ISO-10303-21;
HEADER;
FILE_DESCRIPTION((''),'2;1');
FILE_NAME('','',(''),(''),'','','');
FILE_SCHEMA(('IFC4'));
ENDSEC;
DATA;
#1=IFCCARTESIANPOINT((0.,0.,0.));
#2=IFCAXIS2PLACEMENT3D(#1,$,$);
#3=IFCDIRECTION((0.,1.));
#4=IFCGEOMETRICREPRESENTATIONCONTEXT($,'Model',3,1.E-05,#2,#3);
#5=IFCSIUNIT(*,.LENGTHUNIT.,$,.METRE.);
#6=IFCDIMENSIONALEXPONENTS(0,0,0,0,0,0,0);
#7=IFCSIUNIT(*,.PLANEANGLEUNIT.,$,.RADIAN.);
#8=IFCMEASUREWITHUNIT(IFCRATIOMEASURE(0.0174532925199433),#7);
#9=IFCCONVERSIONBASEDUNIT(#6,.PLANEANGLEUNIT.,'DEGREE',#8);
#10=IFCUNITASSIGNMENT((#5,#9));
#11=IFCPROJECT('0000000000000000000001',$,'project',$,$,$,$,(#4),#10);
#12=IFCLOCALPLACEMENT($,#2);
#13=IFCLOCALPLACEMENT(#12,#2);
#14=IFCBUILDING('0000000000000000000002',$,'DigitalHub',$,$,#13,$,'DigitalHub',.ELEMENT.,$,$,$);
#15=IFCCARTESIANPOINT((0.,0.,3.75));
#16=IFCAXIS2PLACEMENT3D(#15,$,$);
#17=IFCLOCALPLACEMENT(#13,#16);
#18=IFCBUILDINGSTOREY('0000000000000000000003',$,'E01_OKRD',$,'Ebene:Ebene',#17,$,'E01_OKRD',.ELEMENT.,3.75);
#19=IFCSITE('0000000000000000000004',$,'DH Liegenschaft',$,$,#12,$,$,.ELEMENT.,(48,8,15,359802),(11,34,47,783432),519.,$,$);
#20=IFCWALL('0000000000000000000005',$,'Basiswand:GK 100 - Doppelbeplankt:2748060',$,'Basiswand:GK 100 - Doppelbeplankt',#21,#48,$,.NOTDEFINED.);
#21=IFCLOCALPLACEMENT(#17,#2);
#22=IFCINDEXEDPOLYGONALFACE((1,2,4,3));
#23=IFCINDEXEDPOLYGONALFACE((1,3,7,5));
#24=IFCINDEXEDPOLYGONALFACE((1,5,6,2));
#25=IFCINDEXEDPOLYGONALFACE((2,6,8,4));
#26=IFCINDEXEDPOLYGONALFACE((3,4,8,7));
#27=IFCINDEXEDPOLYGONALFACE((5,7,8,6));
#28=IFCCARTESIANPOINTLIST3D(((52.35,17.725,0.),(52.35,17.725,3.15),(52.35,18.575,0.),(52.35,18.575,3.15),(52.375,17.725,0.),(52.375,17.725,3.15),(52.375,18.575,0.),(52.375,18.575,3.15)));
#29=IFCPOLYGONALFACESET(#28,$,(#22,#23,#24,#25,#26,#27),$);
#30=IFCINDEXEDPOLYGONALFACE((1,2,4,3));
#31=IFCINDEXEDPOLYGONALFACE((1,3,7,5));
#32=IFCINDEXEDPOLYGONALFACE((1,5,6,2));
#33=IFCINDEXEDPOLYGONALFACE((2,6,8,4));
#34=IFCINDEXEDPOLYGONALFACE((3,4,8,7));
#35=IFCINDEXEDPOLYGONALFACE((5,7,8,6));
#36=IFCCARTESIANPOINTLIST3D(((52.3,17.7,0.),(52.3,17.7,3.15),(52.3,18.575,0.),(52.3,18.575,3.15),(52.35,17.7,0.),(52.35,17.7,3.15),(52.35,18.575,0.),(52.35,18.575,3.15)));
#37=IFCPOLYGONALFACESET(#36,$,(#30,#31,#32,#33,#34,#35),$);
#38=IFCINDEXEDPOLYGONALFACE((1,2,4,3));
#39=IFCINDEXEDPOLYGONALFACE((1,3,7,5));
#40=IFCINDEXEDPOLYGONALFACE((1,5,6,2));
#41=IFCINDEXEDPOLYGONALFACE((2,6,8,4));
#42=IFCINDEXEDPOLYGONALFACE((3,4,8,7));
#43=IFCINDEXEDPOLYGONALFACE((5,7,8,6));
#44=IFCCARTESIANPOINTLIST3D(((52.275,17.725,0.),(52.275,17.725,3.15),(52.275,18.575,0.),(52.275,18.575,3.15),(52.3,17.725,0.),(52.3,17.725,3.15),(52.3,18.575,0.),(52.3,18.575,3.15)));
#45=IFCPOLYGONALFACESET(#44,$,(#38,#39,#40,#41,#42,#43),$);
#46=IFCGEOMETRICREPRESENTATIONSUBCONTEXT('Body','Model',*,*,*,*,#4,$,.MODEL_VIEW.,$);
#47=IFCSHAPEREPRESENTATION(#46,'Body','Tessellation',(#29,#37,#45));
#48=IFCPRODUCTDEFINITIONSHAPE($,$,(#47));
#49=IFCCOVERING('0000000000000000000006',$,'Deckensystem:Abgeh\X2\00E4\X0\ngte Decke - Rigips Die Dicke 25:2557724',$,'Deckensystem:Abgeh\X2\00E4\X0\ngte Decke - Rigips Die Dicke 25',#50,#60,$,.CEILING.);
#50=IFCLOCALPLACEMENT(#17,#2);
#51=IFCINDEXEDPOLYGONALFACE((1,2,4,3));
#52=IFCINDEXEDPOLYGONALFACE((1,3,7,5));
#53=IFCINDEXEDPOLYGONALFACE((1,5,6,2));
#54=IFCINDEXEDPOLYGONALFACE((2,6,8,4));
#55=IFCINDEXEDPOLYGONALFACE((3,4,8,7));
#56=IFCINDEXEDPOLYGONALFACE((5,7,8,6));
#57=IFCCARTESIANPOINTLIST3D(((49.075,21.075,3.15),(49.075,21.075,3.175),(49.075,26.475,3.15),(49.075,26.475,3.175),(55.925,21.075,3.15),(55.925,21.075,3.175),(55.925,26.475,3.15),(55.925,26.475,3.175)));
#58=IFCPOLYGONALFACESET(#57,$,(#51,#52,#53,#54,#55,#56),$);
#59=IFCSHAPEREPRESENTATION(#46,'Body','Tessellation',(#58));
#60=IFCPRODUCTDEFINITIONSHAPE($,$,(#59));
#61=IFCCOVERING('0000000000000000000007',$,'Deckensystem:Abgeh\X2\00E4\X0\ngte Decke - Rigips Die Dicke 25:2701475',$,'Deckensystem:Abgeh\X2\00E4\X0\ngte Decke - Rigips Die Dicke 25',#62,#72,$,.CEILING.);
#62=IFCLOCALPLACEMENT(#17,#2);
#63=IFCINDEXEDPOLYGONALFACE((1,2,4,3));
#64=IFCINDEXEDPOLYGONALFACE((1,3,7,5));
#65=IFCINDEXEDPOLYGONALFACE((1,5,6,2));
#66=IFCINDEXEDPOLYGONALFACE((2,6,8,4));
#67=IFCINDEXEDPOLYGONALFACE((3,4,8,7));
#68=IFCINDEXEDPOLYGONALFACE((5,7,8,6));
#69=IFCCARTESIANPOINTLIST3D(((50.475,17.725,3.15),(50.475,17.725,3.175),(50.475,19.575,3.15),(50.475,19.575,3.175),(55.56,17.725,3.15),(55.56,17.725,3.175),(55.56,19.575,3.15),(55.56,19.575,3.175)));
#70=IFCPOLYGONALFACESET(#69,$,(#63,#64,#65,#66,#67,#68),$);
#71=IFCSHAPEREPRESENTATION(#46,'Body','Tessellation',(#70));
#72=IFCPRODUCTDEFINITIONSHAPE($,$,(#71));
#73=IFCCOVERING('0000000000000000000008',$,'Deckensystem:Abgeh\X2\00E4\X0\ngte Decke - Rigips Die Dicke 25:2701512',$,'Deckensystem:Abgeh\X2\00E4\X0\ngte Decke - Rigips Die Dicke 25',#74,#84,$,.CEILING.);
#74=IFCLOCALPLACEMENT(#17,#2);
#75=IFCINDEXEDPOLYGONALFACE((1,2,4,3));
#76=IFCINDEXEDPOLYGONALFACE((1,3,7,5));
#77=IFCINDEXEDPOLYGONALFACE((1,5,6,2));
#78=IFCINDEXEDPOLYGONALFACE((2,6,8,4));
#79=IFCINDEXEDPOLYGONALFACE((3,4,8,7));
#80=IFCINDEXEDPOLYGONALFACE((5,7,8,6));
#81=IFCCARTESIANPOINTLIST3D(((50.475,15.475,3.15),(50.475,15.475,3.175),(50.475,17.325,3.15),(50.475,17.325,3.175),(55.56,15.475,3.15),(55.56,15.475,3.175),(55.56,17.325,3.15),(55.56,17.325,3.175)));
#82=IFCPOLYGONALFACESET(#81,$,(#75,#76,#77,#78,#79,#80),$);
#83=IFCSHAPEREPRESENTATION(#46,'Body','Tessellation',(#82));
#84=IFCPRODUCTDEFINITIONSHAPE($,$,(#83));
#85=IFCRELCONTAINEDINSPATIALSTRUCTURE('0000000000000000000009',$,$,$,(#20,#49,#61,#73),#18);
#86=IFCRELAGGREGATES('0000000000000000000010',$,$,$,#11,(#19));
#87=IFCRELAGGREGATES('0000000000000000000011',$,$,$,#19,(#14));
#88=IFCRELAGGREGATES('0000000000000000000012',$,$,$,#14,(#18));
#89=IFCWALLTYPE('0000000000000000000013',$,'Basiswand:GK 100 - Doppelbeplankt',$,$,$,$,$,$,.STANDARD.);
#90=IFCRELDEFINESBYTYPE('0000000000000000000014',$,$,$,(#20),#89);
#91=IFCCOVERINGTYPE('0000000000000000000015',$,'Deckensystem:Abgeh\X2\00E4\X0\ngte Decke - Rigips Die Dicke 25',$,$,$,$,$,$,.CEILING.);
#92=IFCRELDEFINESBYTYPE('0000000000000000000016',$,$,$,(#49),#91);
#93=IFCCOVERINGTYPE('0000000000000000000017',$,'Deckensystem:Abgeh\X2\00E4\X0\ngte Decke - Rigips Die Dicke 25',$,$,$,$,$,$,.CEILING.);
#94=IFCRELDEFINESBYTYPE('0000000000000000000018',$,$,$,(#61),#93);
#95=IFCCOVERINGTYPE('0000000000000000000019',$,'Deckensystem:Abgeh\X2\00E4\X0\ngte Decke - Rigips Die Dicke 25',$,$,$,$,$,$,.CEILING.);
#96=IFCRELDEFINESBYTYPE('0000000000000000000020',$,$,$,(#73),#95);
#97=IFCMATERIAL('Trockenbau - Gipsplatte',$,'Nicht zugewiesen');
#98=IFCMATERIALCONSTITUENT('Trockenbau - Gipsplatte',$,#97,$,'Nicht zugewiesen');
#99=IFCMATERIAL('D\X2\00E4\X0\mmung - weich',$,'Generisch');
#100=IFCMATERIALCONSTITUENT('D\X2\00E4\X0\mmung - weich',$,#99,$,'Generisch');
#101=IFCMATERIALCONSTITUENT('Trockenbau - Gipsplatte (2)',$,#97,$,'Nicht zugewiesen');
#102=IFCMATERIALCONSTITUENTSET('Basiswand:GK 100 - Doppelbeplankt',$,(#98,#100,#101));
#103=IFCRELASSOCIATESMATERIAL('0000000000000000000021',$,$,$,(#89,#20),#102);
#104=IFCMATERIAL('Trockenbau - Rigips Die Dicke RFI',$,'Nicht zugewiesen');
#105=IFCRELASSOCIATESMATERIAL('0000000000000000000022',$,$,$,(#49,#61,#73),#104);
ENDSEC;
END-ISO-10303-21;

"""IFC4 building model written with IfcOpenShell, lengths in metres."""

from ifc_helpers import new_model, entity, si_unit, converted_unit, direction, frame, origin, place, context, subcontext, project, spatial, indexed_curve, outline, extrude, material, constituent, constituent_set, type_object, element, save


model = new_model("IFC4")

# Units and contexts
model_context = context("Model", 3, precision=1e-05, world=origin(), true_north=direction((0.0, 1.0)))
body_context = subcontext(model_context, "Body", "Model", "MODEL_VIEW")
ifc_project = project(units=[si_unit("LENGTHUNIT", "METRE"), converted_unit("PLANEANGLEUNIT", "DEGREE", entity("IfcRatioMeasure", 0.0174532925199433), si_unit("PLANEANGLEUNIT", "RADIAN"), dimensions=[0, 0, 0, 0, 0, 0, 0])], contexts=[model_context])

# Site, building, storey
site_placement = place(None, frame((0.0, 0.0, 0.0)))
site = spatial("IfcSite", under=ifc_project, at=site_placement, Name="DH Liegenschaft", CompositionType="ELEMENT", RefLatitude=(48, 8, 15, 359802), RefLongitude=(11, 34, 47, 783432), RefElevation=519.0)
building_placement = place(site_placement, origin())
building = spatial("IfcBuilding", under=site, at=building_placement, Name="DigitalHub", LongName="DigitalHub", CompositionType="ELEMENT")
storey_placement = place(building_placement, frame((0.0, 0.0, 3.75)))
storey = spatial("IfcBuildingStorey", under=building, at=storey_placement, Name="E01_OKRD", ObjectType="Ebene:Ebene", LongName="E01_OKRD", CompositionType="ELEMENT", Elevation=3.75)

# Wall
ifc_material_1 = material(Name="Trockenbau - Gipsplatte", Category="Nicht zugewiesen")
ifc_constituent_1 = constituent(ifc_material_1, Name="Trockenbau - Gipsplatte", Category="Nicht zugewiesen")
ifc_material_2 = material(Name="Dämmung - weich", Category="Generisch")
ifc_constituent_2 = constituent(ifc_material_2, Name="Dämmung - weich", Category="Generisch")
ifc_constituent_3 = constituent(ifc_material_1, Name="Trockenbau - Gipsplatte (2)", Category="Nicht zugewiesen")
ifc_constituent_set_1 = constituent_set(constituents=[ifc_constituent_1, ifc_constituent_2, ifc_constituent_3], Name="Basiswand:GK 100 - Doppelbeplankt")
wall_type_1 = type_object("IfcWallType", Name="Basiswand:GK 100 - Doppelbeplankt", PredefinedType="STANDARD", material=ifc_constituent_set_1)
wall_1_placement = place(storey_placement, frame((52.325, 17.725, 0.0), z_axis=(0.0, 0.0, 1.0), x_axis=(0.0, 1.0, 0.0)))
element("IfcWall", 1, at=wall_1_placement, inside=storey, type_object=wall_type_1, material=ifc_constituent_set_1, Name="Basiswand:GK 100 - Doppelbeplankt:2748060", ObjectType="Basiswand:GK 100 - Doppelbeplankt", PredefinedType="NOTDEFINED", context=body_context, shape_type="SweptSolid", body=[
    extrude(outline(indexed_curve([(-0.0125, -0.425), (0.0125, -0.425), (0.0125, 0.425), (-0.0125, 0.425), (-0.0125, -0.425)], self_intersect=False)), frame((0.425, -0.0375, 0.0), z_axis=(0.0, 0.0, 1.0), x_axis=(0.0, 1.0, 0.0)), (0.0, 0.0, 1.0), 3.15),
    extrude(outline(indexed_curve([(-0.4375, -0.025), (0.4375, -0.025), (0.4375, 0.025), (-0.4375, 0.025), (-0.4375, -0.025)], self_intersect=False)), frame((0.4125, 0.0, 0.0)), (0.0, 0.0, 1.0), 3.15),
    extrude(outline(indexed_curve([(-0.0125, -0.425), (0.0125, -0.425), (0.0125, 0.425), (-0.0125, 0.425), (-0.0125, -0.425)], self_intersect=False)), frame((0.425, 0.0375, 0.0), z_axis=(0.0, 0.0, 1.0), x_axis=(0.0, -1.0, 0.0)), (0.0, 0.0, 1.0), 3.15),
])

# Coverings
ifc_material_3 = material(Name="Trockenbau - Rigips Die Dicke RFI", Category="Nicht zugewiesen")
covering_type_1 = type_object("IfcCoveringType", Name="Deckensystem:Abgehängte Decke - Rigips Die Dicke 25", PredefinedType="CEILING")
covering_1_placement = place(storey_placement, frame((49.075, 21.075, 3.15)))
element("IfcCovering", 2, at=covering_1_placement, inside=storey, type_object=covering_type_1, material=ifc_material_3, Name="Deckensystem:Abgehängte Decke - Rigips Die Dicke 25:2557724", ObjectType="Deckensystem:Abgehängte Decke - Rigips Die Dicke 25", PredefinedType="CEILING", context=body_context, shape_type="SweptSolid", body=[
    extrude(outline(indexed_curve([(-3.425, -2.7), (3.425, -2.7), (3.425, 2.7), (-3.425, 2.7), (-3.425, -2.7)], self_intersect=False)), frame((3.425, 2.7, 0.0), z_axis=(0.0, 0.0, 1.0), x_axis=(-1.0, 0.0, 0.0)), (0.0, 0.0, 1.0), 0.025),
])
covering_type_2 = type_object("IfcCoveringType", Name="Deckensystem:Abgehängte Decke - Rigips Die Dicke 25", PredefinedType="CEILING")
covering_2_placement = place(storey_placement, frame((50.475, 17.725, 3.15)))
element("IfcCovering", 3, at=covering_2_placement, inside=storey, type_object=covering_type_2, material=ifc_material_3, Name="Deckensystem:Abgehängte Decke - Rigips Die Dicke 25:2701475", ObjectType="Deckensystem:Abgehängte Decke - Rigips Die Dicke 25", PredefinedType="CEILING", context=body_context, shape_type="SweptSolid", body=[
    extrude(outline(indexed_curve([(-2.5425, -0.925), (2.5425, -0.925), (2.5425, 0.925), (-2.5425, 0.925), (-2.5425, -0.925)], self_intersect=False)), frame((2.5425, 0.925, 0.0), z_axis=(0.0, 0.0, 1.0), x_axis=(-1.0, 0.0, 0.0)), (0.0, 0.0, 1.0), 0.025),
])
covering_type_3 = type_object("IfcCoveringType", Name="Deckensystem:Abgehängte Decke - Rigips Die Dicke 25", PredefinedType="CEILING")
covering_3_placement = place(storey_placement, frame((50.475, 15.475, 3.15)))
element("IfcCovering", 4, at=covering_3_placement, inside=storey, type_object=covering_type_3, material=ifc_material_3, Name="Deckensystem:Abgehängte Decke - Rigips Die Dicke 25:2701512", ObjectType="Deckensystem:Abgehängte Decke - Rigips Die Dicke 25", PredefinedType="CEILING", context=body_context, shape_type="SweptSolid", body=[
    extrude(outline(indexed_curve([(-2.5425, -0.925), (2.5425, -0.925), (2.5425, 0.925), (-2.5425, 0.925), (-2.5425, -0.925)], self_intersect=False)), frame((2.5425, 0.925, 0.0), z_axis=(0.0, 0.0, 1.0), x_axis=(-1.0, 0.0, 0.0)), (0.0, 0.0, 1.0), 0.025),
])

save(model, "model.ifc")
